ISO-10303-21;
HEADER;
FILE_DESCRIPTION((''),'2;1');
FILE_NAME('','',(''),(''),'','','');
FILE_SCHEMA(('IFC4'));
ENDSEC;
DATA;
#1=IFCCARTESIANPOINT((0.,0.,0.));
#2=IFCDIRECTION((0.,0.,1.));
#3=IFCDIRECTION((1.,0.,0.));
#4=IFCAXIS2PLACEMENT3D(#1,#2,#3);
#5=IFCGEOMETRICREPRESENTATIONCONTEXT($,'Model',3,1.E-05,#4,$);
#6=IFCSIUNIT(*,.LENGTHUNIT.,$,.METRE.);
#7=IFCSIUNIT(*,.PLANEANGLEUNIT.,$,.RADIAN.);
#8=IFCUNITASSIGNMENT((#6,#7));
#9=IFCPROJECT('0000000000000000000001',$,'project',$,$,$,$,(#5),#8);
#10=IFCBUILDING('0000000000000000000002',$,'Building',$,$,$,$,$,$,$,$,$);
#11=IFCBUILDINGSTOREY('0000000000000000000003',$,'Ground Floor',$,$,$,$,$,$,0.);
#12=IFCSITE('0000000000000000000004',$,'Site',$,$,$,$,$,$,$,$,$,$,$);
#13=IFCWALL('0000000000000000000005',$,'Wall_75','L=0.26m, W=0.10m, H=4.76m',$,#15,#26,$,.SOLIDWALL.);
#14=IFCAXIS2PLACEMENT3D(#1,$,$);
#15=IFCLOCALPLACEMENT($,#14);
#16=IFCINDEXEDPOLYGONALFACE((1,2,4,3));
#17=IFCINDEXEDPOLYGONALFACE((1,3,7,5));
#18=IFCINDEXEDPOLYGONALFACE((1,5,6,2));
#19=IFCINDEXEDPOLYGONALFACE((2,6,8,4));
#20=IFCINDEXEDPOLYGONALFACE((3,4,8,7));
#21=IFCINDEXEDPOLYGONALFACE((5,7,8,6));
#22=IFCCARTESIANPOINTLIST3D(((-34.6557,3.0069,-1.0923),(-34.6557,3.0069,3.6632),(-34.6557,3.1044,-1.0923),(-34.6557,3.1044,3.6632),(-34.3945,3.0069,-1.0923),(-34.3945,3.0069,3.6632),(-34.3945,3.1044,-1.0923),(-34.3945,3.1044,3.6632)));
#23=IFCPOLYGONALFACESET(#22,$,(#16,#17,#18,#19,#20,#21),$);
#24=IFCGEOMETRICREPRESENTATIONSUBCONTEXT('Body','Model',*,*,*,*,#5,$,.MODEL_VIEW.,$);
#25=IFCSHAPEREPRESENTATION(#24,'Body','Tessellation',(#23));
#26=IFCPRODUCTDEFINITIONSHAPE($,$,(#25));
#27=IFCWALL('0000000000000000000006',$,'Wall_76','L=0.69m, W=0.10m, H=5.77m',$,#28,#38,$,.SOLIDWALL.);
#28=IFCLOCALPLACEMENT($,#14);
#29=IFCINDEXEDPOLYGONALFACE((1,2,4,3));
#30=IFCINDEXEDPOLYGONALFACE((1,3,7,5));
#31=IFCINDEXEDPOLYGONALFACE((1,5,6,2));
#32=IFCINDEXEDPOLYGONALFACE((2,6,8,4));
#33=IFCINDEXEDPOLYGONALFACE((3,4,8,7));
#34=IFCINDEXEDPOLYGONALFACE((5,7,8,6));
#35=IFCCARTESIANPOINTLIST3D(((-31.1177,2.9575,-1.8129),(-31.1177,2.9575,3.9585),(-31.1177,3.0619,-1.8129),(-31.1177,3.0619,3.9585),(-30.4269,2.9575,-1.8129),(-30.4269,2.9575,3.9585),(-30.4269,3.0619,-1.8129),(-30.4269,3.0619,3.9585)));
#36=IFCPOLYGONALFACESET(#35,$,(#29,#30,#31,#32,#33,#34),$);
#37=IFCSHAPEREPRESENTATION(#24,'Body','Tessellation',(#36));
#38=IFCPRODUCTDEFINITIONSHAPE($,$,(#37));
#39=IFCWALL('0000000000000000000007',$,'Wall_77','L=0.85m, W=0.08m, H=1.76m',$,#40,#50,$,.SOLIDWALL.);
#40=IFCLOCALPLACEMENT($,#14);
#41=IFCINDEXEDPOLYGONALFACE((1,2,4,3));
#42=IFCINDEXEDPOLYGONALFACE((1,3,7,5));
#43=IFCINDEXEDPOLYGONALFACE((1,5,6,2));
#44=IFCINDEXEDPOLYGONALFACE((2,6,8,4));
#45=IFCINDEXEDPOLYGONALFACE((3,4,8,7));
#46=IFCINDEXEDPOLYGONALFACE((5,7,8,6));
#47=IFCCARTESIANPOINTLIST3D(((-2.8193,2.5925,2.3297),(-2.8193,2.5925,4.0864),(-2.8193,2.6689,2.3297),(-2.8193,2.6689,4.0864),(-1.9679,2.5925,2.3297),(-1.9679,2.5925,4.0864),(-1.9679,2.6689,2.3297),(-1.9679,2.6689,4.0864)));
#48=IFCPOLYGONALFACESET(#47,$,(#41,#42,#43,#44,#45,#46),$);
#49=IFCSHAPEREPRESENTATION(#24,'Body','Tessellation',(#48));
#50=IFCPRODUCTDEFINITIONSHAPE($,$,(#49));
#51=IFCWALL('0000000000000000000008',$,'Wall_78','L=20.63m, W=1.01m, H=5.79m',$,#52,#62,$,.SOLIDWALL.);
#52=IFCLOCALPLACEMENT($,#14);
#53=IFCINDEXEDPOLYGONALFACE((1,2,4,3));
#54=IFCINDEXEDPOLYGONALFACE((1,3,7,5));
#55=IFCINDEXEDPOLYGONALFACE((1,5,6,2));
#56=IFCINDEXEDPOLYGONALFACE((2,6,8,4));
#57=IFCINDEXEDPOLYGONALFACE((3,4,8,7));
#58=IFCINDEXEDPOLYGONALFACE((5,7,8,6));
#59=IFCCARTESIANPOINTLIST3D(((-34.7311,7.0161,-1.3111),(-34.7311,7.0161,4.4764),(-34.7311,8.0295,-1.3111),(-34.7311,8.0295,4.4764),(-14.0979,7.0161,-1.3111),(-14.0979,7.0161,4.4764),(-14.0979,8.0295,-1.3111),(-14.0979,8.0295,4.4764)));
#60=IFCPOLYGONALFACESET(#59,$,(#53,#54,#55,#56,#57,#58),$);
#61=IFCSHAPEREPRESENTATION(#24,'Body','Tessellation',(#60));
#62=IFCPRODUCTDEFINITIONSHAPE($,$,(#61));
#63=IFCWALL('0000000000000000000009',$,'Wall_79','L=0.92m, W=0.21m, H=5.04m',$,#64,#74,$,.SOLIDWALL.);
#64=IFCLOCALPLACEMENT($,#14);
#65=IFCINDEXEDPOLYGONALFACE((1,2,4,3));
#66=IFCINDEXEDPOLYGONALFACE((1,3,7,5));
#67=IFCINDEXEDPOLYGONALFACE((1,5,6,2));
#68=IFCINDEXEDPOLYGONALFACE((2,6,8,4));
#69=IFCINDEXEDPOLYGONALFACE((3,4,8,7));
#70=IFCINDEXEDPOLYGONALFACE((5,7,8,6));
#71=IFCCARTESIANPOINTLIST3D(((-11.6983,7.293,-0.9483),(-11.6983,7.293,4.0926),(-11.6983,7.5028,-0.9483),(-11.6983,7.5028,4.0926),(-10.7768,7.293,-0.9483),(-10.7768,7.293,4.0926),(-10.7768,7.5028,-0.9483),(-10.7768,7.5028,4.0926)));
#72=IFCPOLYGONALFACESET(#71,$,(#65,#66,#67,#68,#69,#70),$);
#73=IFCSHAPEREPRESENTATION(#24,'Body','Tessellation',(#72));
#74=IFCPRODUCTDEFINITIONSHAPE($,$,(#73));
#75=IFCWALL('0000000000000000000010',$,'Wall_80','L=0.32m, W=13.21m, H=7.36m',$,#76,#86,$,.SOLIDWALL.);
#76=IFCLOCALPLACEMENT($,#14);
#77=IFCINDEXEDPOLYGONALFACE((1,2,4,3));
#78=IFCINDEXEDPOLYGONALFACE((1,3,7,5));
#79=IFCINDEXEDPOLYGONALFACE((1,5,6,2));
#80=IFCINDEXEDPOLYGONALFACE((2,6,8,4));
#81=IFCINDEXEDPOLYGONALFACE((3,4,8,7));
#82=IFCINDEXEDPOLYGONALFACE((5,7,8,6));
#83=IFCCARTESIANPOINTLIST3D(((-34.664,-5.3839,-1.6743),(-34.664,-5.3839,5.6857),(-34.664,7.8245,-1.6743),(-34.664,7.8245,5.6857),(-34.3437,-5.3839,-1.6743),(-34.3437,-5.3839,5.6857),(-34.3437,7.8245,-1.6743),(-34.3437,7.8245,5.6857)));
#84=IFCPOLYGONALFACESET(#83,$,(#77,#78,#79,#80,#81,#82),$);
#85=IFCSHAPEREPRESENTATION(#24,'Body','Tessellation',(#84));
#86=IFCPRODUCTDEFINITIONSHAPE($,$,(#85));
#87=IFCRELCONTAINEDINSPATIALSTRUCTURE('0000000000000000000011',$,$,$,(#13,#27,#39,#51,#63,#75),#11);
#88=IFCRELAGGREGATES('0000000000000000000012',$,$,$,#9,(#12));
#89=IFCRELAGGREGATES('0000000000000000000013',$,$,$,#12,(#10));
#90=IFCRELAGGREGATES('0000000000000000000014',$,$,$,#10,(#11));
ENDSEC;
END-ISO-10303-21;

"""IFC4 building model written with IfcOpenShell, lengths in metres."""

from ifc_helpers import new_model, si_unit, frame, origin_with_axes, origin_2d, context, subcontext, project, spatial, rectangle, extrude, element, save


model = new_model("IFC4")

# Units and contexts
model_context = context("Model", 3, precision=1e-05, world=origin_with_axes())
body_context = subcontext(model_context, "Body", "Model", "MODEL_VIEW")
ifc_project = project(units=[si_unit("LENGTHUNIT", "METRE"), si_unit("PLANEANGLEUNIT", "RADIAN")], contexts=[model_context])

# Site, building, storey
site = spatial("IfcSite", under=ifc_project, Name="Site")
building = spatial("IfcBuilding", under=site, Name="Building")
storey = spatial("IfcBuildingStorey", under=building, Name="Ground Floor", Elevation=0.0)

# Walls
element("IfcWall", 1, inside=storey, Name="Wall_75", Description="L=0.26m, W=0.10m, H=4.76m", PredefinedType="SOLIDWALL", context=body_context, shape_type="SweptSolid", body=[
    extrude(rectangle(XDim=0.2612, YDim=0.0975, at=origin_2d()), frame((-34.5251, 3.0556, -1.0923), z_axis=(0.0, 0.0, 1.0), x_axis=(1.0, 0.0, 0.0)), (0.0, 0.0, 1.0), 4.7555),
])
element("IfcWall", 2, inside=storey, Name="Wall_76", Description="L=0.69m, W=0.10m, H=5.77m", PredefinedType="SOLIDWALL", context=body_context, shape_type="SweptSolid", body=[
    extrude(rectangle(XDim=0.6907, YDim=0.1044, at=origin_2d()), frame((-30.7723, 3.0097, -1.8129), z_axis=(0.0, 0.0, 1.0), x_axis=(1.0, 0.0, 0.0)), (0.0, 0.0, 1.0), 5.7715),
])
element("IfcWall", 3, inside=storey, Name="Wall_77", Description="L=0.85m, W=0.08m, H=1.76m", PredefinedType="SOLIDWALL", context=body_context, shape_type="SweptSolid", body=[
    extrude(rectangle(XDim=0.8514, YDim=0.0764, at=origin_2d()), frame((-2.3936, 2.6307, 2.3297), z_axis=(0.0, 0.0, 1.0), x_axis=(1.0, 0.0, 0.0)), (0.0, 0.0, 1.0), 1.7568),
])
element("IfcWall", 4, inside=storey, Name="Wall_78", Description="L=20.63m, W=1.01m, H=5.79m", PredefinedType="SOLIDWALL", context=body_context, shape_type="SweptSolid", body=[
    extrude(rectangle(XDim=20.6332, YDim=1.0133, at=origin_2d()), frame((-24.4145, 7.5228, -1.3111), z_axis=(0.0, 0.0, 1.0), x_axis=(1.0, 0.0, 0.0)), (0.0, 0.0, 1.0), 5.7875),
])
element("IfcWall", 5, inside=storey, Name="Wall_79", Description="L=0.92m, W=0.21m, H=5.04m", PredefinedType="SOLIDWALL", context=body_context, shape_type="SweptSolid", body=[
    extrude(rectangle(XDim=0.9215, YDim=0.2097, at=origin_2d()), frame((-11.2375, 7.3979, -0.9483), z_axis=(0.0, 0.0, 1.0), x_axis=(1.0, 0.0, 0.0)), (0.0, 0.0, 1.0), 5.0409),
])
element("IfcWall", 6, inside=storey, Name="Wall_80", Description="L=0.32m, W=13.21m, H=7.36m", PredefinedType="SOLIDWALL", context=body_context, shape_type="SweptSolid", body=[
    extrude(rectangle(XDim=0.3203, YDim=13.2084, at=origin_2d()), frame((-34.5038, 1.2203, -1.6743), z_axis=(0.0, 0.0, 1.0), x_axis=(1.0, 0.0, 0.0)), (0.0, 0.0, 1.0), 7.36),
])

save(model, "model.ifc")
